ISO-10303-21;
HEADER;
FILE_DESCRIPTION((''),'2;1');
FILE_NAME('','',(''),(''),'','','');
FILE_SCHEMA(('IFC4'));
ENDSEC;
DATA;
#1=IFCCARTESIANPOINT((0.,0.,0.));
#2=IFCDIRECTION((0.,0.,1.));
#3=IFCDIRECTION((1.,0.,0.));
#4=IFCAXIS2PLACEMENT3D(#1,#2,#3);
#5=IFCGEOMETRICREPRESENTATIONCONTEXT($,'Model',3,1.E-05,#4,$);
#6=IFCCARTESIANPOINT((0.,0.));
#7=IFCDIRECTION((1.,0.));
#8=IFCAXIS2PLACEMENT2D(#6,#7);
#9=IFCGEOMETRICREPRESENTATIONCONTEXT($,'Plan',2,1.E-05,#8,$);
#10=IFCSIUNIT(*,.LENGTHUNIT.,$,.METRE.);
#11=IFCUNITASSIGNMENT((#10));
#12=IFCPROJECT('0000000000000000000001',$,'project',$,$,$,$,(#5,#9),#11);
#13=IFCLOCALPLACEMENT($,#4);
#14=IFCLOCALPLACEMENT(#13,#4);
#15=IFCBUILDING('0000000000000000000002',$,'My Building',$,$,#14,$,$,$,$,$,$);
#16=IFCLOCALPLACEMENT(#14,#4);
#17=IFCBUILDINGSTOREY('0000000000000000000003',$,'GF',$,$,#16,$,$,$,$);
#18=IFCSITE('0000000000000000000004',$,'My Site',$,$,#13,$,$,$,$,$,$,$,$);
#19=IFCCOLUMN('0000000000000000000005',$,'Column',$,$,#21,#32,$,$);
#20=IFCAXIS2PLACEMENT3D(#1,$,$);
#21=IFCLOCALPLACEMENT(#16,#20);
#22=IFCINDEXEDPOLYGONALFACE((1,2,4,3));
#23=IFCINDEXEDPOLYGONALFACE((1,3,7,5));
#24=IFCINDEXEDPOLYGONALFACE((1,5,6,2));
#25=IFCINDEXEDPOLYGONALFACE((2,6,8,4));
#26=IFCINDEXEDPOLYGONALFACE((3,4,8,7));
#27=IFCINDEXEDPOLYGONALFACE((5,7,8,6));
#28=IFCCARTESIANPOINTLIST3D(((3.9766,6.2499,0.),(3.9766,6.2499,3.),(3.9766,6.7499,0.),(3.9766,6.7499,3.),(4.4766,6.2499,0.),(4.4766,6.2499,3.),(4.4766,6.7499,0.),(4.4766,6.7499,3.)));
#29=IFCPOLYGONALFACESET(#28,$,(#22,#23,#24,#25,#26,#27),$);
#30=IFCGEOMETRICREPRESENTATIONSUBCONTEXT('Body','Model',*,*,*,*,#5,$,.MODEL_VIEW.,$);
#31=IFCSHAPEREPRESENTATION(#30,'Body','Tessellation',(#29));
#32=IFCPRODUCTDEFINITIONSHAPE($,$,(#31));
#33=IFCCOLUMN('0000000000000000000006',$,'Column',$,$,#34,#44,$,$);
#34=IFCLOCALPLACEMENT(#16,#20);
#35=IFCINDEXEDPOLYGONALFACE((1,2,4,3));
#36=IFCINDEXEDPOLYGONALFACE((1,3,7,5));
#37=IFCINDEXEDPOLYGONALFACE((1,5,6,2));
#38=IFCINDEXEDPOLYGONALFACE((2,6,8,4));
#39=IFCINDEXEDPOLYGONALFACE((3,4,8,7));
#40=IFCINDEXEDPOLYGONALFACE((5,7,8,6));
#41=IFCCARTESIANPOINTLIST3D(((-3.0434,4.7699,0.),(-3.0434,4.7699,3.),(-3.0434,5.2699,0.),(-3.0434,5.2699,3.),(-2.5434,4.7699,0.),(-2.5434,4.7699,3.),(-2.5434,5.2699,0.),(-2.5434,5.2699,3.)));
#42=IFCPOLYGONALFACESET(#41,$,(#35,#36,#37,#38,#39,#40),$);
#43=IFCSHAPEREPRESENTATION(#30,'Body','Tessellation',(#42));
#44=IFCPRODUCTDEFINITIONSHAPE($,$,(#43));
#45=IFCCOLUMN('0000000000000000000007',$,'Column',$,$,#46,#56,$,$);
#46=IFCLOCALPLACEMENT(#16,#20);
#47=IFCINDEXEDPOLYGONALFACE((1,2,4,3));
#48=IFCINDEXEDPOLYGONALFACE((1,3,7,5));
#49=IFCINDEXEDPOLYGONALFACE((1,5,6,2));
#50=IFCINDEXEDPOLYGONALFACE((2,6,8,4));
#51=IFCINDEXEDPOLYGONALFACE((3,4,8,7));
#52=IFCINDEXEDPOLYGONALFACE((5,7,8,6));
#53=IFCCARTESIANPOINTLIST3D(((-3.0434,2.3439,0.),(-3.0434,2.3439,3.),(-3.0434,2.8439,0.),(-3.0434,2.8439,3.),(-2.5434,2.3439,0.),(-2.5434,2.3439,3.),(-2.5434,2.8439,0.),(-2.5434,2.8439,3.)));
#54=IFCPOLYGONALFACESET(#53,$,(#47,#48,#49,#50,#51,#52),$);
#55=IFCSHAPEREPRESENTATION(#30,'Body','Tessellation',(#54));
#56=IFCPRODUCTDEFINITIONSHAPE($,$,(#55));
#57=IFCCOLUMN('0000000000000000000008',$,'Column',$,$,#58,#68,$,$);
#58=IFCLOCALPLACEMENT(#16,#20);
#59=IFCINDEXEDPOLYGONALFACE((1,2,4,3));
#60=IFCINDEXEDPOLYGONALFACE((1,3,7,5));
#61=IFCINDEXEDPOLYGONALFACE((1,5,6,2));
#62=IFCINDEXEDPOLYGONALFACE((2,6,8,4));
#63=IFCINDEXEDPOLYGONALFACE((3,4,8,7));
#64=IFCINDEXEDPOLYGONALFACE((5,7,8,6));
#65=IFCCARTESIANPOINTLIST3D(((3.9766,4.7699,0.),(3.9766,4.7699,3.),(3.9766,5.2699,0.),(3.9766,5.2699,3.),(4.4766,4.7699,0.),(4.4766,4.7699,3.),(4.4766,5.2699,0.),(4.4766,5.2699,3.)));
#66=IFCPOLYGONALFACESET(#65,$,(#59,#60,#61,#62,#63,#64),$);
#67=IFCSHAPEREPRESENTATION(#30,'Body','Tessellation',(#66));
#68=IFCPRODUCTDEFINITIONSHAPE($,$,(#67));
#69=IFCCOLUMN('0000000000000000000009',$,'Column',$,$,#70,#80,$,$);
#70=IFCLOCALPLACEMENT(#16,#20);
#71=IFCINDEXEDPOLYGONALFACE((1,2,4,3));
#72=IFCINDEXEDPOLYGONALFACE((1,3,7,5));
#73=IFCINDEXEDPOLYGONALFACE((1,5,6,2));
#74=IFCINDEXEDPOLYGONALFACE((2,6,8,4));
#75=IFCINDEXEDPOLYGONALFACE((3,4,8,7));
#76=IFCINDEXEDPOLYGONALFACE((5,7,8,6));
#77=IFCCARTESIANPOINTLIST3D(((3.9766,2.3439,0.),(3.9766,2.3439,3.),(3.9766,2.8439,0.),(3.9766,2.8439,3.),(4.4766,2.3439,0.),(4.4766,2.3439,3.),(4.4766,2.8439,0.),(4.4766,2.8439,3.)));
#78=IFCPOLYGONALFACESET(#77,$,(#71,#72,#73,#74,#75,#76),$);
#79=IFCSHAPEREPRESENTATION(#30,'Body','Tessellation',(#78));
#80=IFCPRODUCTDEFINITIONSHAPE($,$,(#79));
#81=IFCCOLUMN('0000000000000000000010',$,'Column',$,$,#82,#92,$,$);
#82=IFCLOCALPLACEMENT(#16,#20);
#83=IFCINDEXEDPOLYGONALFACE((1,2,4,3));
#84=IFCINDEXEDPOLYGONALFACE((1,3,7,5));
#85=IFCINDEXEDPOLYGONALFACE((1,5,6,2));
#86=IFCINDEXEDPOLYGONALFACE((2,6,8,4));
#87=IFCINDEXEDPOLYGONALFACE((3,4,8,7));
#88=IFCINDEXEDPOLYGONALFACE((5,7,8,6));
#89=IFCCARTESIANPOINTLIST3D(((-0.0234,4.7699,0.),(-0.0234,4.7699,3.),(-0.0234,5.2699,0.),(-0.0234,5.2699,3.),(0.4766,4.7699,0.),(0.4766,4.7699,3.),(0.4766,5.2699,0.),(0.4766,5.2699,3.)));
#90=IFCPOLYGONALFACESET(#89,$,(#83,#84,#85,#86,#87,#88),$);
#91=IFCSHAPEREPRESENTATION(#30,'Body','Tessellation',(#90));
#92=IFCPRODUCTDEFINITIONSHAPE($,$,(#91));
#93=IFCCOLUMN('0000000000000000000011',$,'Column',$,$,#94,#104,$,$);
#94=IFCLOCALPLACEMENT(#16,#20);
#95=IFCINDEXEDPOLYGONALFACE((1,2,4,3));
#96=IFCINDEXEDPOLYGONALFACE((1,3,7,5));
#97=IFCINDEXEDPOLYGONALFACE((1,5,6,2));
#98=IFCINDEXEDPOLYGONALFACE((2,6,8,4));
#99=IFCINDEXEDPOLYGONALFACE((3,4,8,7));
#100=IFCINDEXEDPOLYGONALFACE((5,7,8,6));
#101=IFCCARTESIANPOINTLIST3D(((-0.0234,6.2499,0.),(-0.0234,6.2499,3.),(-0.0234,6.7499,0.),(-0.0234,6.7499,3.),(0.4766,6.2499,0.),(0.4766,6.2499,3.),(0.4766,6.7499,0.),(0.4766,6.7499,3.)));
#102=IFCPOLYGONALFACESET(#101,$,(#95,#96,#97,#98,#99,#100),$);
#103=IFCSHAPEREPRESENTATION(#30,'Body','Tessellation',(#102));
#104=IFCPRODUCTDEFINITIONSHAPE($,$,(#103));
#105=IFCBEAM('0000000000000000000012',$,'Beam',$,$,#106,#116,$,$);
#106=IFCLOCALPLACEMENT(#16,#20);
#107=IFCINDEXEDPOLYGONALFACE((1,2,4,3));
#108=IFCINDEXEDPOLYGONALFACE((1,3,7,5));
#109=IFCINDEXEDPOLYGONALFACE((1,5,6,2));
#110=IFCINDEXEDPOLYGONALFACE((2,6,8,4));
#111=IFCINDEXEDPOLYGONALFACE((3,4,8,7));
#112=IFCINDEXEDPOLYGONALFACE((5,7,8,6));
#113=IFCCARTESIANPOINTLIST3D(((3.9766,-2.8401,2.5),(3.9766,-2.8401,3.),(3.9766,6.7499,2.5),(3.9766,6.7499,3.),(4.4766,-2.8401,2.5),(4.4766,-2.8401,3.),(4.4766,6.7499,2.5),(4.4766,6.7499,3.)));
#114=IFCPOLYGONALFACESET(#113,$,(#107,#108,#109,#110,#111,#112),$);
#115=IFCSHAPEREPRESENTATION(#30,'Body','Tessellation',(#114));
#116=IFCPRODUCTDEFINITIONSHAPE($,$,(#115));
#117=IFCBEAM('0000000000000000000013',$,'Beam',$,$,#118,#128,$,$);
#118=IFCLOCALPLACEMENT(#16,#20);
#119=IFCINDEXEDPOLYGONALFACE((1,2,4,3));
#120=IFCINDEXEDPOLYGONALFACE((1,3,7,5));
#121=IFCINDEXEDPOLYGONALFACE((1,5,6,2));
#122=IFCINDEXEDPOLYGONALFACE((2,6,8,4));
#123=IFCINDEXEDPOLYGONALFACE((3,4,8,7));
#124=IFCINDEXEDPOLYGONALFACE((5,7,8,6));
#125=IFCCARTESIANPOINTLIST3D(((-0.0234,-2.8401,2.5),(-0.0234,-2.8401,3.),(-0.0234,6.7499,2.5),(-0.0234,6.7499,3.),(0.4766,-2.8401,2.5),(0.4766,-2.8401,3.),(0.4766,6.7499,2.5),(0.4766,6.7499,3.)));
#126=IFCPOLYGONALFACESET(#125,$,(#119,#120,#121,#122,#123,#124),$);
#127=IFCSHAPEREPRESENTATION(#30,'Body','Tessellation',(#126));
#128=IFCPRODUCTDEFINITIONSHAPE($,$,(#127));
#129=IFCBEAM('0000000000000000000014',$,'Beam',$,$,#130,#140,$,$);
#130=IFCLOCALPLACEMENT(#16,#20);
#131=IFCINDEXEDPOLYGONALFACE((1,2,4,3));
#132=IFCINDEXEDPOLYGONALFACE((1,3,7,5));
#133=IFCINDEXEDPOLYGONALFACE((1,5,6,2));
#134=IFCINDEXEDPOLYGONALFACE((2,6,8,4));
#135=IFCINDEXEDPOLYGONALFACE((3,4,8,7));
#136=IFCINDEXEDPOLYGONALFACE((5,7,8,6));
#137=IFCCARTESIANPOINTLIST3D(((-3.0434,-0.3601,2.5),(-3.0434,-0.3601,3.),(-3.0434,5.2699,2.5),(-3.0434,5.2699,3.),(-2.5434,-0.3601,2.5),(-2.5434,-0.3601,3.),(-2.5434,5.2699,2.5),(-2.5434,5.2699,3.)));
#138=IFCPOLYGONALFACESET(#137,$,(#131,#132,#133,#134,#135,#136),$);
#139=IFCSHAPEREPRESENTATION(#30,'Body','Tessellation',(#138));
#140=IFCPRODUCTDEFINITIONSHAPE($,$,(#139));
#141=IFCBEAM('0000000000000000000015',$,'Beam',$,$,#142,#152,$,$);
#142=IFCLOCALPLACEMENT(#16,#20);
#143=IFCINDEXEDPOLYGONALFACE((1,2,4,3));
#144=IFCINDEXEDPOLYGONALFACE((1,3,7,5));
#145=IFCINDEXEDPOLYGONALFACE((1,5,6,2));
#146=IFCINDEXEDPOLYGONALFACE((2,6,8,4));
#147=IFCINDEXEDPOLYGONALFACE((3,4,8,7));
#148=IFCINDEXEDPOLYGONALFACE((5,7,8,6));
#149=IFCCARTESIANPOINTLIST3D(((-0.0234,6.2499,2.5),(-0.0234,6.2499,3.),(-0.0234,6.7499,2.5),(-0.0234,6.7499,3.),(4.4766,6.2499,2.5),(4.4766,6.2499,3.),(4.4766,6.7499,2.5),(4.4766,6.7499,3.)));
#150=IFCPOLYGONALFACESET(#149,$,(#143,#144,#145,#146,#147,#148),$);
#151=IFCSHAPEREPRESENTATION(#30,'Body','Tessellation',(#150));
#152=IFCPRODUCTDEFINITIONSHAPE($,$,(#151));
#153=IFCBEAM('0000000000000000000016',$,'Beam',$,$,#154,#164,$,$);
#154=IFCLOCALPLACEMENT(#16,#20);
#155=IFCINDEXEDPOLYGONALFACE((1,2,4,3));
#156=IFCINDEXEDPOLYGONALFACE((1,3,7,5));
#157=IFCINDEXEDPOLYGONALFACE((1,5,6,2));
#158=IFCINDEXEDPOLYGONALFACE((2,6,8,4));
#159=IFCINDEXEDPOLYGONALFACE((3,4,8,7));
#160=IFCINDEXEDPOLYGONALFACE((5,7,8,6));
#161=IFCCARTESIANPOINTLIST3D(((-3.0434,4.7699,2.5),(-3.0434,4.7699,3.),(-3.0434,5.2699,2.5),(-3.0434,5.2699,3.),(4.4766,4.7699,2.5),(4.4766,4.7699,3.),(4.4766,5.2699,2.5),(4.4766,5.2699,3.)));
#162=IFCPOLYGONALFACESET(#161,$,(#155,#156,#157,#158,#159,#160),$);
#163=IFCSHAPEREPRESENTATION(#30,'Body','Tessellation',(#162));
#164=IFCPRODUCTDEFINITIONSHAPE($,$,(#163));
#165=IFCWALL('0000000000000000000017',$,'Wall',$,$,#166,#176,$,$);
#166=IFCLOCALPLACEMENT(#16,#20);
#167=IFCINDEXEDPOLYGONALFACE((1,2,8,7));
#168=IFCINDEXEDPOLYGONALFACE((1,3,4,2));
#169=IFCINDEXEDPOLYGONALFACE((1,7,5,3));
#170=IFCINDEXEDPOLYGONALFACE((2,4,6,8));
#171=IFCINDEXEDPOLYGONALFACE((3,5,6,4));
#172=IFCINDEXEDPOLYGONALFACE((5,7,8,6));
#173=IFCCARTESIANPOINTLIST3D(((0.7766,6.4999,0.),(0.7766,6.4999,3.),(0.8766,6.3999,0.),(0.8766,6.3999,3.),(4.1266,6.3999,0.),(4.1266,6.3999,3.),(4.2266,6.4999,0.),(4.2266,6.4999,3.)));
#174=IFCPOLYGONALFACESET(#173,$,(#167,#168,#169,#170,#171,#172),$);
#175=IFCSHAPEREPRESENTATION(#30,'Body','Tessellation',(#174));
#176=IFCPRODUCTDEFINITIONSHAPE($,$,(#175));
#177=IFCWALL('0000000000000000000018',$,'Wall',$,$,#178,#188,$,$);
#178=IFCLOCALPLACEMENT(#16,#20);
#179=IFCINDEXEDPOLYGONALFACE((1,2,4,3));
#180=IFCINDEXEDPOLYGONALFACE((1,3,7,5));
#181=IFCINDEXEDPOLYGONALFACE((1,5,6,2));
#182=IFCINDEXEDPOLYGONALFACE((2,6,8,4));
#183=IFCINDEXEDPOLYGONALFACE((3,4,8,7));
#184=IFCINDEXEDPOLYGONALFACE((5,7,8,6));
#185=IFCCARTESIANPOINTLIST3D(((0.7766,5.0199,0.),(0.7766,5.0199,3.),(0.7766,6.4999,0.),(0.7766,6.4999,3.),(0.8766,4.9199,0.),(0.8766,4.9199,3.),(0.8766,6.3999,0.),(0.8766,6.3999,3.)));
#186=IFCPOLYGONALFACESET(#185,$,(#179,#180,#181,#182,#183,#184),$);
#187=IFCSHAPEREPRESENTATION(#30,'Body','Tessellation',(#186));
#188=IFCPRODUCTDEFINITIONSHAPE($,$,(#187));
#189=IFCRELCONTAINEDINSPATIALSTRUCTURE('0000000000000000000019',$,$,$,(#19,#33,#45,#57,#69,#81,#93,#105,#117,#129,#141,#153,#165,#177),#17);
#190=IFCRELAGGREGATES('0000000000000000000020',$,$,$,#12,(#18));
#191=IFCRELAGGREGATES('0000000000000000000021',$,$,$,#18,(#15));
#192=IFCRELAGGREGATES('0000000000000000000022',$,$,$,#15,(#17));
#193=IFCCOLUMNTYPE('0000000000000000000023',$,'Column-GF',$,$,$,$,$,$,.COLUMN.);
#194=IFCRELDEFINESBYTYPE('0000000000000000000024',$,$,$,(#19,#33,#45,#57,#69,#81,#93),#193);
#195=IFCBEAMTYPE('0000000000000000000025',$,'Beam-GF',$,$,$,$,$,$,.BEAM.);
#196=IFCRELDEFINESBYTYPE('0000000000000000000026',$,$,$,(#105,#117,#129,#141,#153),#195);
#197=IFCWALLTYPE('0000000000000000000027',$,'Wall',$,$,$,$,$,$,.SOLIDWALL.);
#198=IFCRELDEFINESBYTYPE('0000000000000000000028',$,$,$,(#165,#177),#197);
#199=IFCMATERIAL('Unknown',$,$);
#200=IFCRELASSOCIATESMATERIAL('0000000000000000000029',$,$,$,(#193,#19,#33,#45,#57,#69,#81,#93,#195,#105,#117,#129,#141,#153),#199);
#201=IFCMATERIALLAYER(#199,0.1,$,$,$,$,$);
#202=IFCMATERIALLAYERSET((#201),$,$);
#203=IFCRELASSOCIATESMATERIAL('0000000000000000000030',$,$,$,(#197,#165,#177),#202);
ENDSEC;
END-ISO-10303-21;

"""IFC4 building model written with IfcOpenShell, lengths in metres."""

from ifc_helpers import new_model, si_unit, frame, origin_with_axes, origin_2d_with_axis, place, context, subcontext, project, spatial, line, indexed_curve, rectangle, outline, extrude, material, layer, layer_set, layer_usage, material_profile, profile_set, profile_usage, type_object, element, save


model = new_model("IFC4")

# Units and contexts
model_context = context("Model", 3, precision=1e-05, world=origin_with_axes())
plan_context = context("Plan", 2, precision=1e-05, world=origin_2d_with_axis())
body_context_1 = subcontext(model_context, "Body", "Model", "MODEL_VIEW")
ifc_project = project(units=[si_unit("LENGTHUNIT", "METRE")], contexts=[model_context, plan_context])

# Site, building, storey
site_placement = place(None, origin_with_axes())
site = spatial("IfcSite", under=ifc_project, at=site_placement, Name="My Site")
building_placement = place(site_placement, origin_with_axes())
building = spatial("IfcBuilding", under=site, at=building_placement, Name="My Building")
storey_placement = place(building_placement, origin_with_axes())
storey = spatial("IfcBuildingStorey", under=building, at=storey_placement, Name="GF")

# Columns
ifc_material_1 = material(Name="Unknown")
ifc_material_profile_1 = material_profile(ifc_material_1, rectangle(XDim=0.5, YDim=0.5))
ifc_profile_set_1 = profile_set([ifc_material_profile_1])
ifc_profile_usage_1 = profile_usage(ifc_profile_set_1, cardinal=5)
column_type = type_object("IfcColumnType", Name="Column-GF", PredefinedType="COLUMN", material=ifc_profile_set_1)
column_1_placement = place(storey_placement, frame((4.2266, 6.4999, 0.0), z_axis=(0.0, 0.0, 1.0), x_axis=(1.0, 0.0, 0.0)))
element("IfcColumn", 1, at=column_1_placement, inside=storey, type_object=column_type, material=ifc_profile_usage_1, Name="Column", context=body_context_1, shape_type="SweptSolid", body=[
    extrude(rectangle(XDim=0.5, YDim=0.5), origin_with_axes(), (0.0, 0.0, 1.0), 3.0),
])
ifc_profile_usage_2 = profile_usage(ifc_profile_set_1, cardinal=5)
column_2_placement = place(storey_placement, frame((-2.7934, 5.0199, 0.0), z_axis=(0.0, 0.0, 1.0), x_axis=(1.0, 0.0, 0.0)))
element("IfcColumn", 2, at=column_2_placement, inside=storey, type_object=column_type, material=ifc_profile_usage_2, Name="Column", context=body_context_1, shape_type="SweptSolid", body=[
    extrude(rectangle(XDim=0.5, YDim=0.5), origin_with_axes(), (0.0, 0.0, 1.0), 3.0),
])
ifc_profile_usage_3 = profile_usage(ifc_profile_set_1, cardinal=5)
column_3_placement = place(storey_placement, frame((-2.7934, 2.5939, 0.0), z_axis=(0.0, 0.0, 1.0), x_axis=(1.0, 0.0, 0.0)))
element("IfcColumn", 3, at=column_3_placement, inside=storey, type_object=column_type, material=ifc_profile_usage_3, Name="Column", context=body_context_1, shape_type="SweptSolid", body=[
    extrude(rectangle(XDim=0.5, YDim=0.5), origin_with_axes(), (0.0, 0.0, 1.0), 3.0),
])
ifc_profile_usage_4 = profile_usage(ifc_profile_set_1, cardinal=5)
column_4_placement = place(storey_placement, frame((4.2266, 5.0199, 0.0), z_axis=(0.0, 0.0, 1.0), x_axis=(1.0, 0.0, 0.0)))
element("IfcColumn", 4, at=column_4_placement, inside=storey, type_object=column_type, material=ifc_profile_usage_4, Name="Column", context=body_context_1, shape_type="SweptSolid", body=[
    extrude(rectangle(XDim=0.5, YDim=0.5), origin_with_axes(), (0.0, 0.0, 1.0), 3.0),
])
ifc_profile_usage_5 = profile_usage(ifc_profile_set_1, cardinal=5)
column_5_placement = place(storey_placement, frame((4.2266, 2.5939, 0.0), z_axis=(0.0, 0.0, 1.0), x_axis=(1.0, 0.0, 0.0)))
element("IfcColumn", 5, at=column_5_placement, inside=storey, type_object=column_type, material=ifc_profile_usage_5, Name="Column", context=body_context_1, shape_type="SweptSolid", body=[
    extrude(rectangle(XDim=0.5, YDim=0.5), origin_with_axes(), (0.0, 0.0, 1.0), 3.0),
])
ifc_profile_usage_6 = profile_usage(ifc_profile_set_1, cardinal=5)
column_6_placement = place(storey_placement, frame((0.2266, 5.0199, 0.0), z_axis=(0.0, 0.0, 1.0), x_axis=(1.0, 0.0, 0.0)))
element("IfcColumn", 6, at=column_6_placement, inside=storey, type_object=column_type, material=ifc_profile_usage_6, Name="Column", context=body_context_1, shape_type="SweptSolid", body=[
    extrude(rectangle(XDim=0.5, YDim=0.5), origin_with_axes(), (0.0, 0.0, 1.0), 3.0),
])
ifc_profile_usage_7 = profile_usage(ifc_profile_set_1, cardinal=5)
column_7_placement = place(storey_placement, frame((0.2266, 6.4999, 0.0), z_axis=(0.0, 0.0, 1.0), x_axis=(1.0, 0.0, 0.0)))
element("IfcColumn", 7, at=column_7_placement, inside=storey, type_object=column_type, material=ifc_profile_usage_7, Name="Column", context=body_context_1, shape_type="SweptSolid", body=[
    extrude(rectangle(XDim=0.5, YDim=0.5), origin_with_axes(), (0.0, 0.0, 1.0), 3.0),
])

# Beams
ifc_material_profile_2 = material_profile(ifc_material_1, rectangle(XDim=0.5, YDim=0.5))
ifc_profile_set_2 = profile_set([ifc_material_profile_2])
ifc_profile_usage_8 = profile_usage(ifc_profile_set_2, cardinal=7)
beam_type = type_object("IfcBeamType", Name="Beam-GF", PredefinedType="BEAM", material=ifc_profile_set_2)
beam_1_placement = place(storey_placement, frame((4.4766, 6.7499, 3.0), z_axis=(0.0, -1.0, 0.0), x_axis=(1.0, 0.0, 0.0)))
element("IfcBeam", 8, at=beam_1_placement, inside=storey, type_object=beam_type, material=ifc_profile_usage_8, Name="Beam", context=body_context_1, shape_type="SweptSolid", body=[
    extrude(rectangle(XDim=0.5, YDim=0.5), frame((-0.25, -0.25, 0.0), z_axis=(0.0, 0.0, 1.0), x_axis=(1.0, 0.0, 0.0)), (0.0, 0.0, 1.0), 9.59),
])
ifc_profile_usage_9 = profile_usage(ifc_profile_set_2, cardinal=7)
beam_2_placement = place(storey_placement, frame((0.4766, 6.7499, 3.0), z_axis=(0.0, -1.0, 0.0), x_axis=(1.0, 0.0, 0.0)))
element("IfcBeam", 9, at=beam_2_placement, inside=storey, type_object=beam_type, material=ifc_profile_usage_9, Name="Beam", context=body_context_1, shape_type="SweptSolid", body=[
    extrude(rectangle(XDim=0.5, YDim=0.5), frame((-0.25, -0.25, 0.0), z_axis=(0.0, 0.0, 1.0), x_axis=(1.0, 0.0, 0.0)), (0.0, 0.0, 1.0), 9.59),
])
ifc_profile_usage_10 = profile_usage(ifc_profile_set_2, cardinal=7)
beam_3_placement = place(storey_placement, frame((-2.5434, 5.2699, 3.0), z_axis=(0.0, -1.0, 0.0), x_axis=(1.0, 0.0, 0.0)))
element("IfcBeam", 10, at=beam_3_placement, inside=storey, type_object=beam_type, material=ifc_profile_usage_10, Name="Beam", context=body_context_1, shape_type="SweptSolid", body=[
    extrude(rectangle(XDim=0.5, YDim=0.5), frame((-0.25, -0.25, 0.0), z_axis=(0.0, 0.0, 1.0), x_axis=(1.0, 0.0, 0.0)), (0.0, 0.0, 1.0), 5.63),
])
ifc_profile_usage_11 = profile_usage(ifc_profile_set_2, cardinal=7)
beam_4_placement = place(storey_placement, frame((4.4766, 6.2499, 3.0), z_axis=(-1.0, 0.0, 0.0), x_axis=(0.0, -1.0, 0.0)))
element("IfcBeam", 11, at=beam_4_placement, inside=storey, type_object=beam_type, material=ifc_profile_usage_11, Name="Beam", context=body_context_1, shape_type="SweptSolid", body=[
    extrude(rectangle(XDim=0.5, YDim=0.5), frame((-0.25, -0.25, 0.0), z_axis=(0.0, 0.0, 1.0), x_axis=(1.0, 0.0, 0.0)), (0.0, 0.0, 1.0), 4.5),
])
ifc_profile_usage_12 = profile_usage(ifc_profile_set_2, cardinal=7)
beam_5_placement = place(storey_placement, frame((4.4766, 4.7699, 3.0), z_axis=(-1.0, 0.0, 0.0), x_axis=(0.0, -1.0, 0.0)))
element("IfcBeam", 12, at=beam_5_placement, inside=storey, type_object=beam_type, material=ifc_profile_usage_12, Name="Beam", context=body_context_1, shape_type="SweptSolid", body=[
    extrude(rectangle(XDim=0.5, YDim=0.5), frame((-0.25, -0.25, 0.0), z_axis=(0.0, 0.0, 1.0), x_axis=(1.0, 0.0, 0.0)), (0.0, 0.0, 1.0), 7.52),
])

# Walls
ifc_layer_1 = layer(ifc_material_1, 0.1)
ifc_layer_set_1 = layer_set([ifc_layer_1])
ifc_layer_usage_1 = layer_usage(ifc_layer_set_1, "AXIS2", "POSITIVE", 0.0)
wall_type = type_object("IfcWallType", Name="Wall", PredefinedType="SOLIDWALL", material=ifc_layer_set_1)
wall_1_placement = place(storey_placement, frame((4.2266, 6.4999, 0.0), z_axis=(0.0, 0.0, 1.0), x_axis=(-1.0, 0.0, 0.0)))
element("IfcWall", 13, at=wall_1_placement, inside=storey, type_object=wall_type, material=ifc_layer_usage_1, Name="Wall", context=body_context_1, shape_type="SweptSolid", body=[
    extrude(outline(indexed_curve([(0.0, 0.0), (0.1, 0.1), (3.35, 0.1), (3.45, 0.0)], segments=[line(1, 2, 3, 4, 1)])), origin_with_axes(), (0.0, 0.0, 1.0), 3.0),
])
ifc_layer_usage_2 = layer_usage(ifc_layer_set_1, "AXIS2", "POSITIVE", 0.0)
wall_2_placement = place(storey_placement, frame((0.7766, 6.4999, 0.0), z_axis=(0.0, 0.0, 1.0), x_axis=(0.0, -1.0, 0.0)))
element("IfcWall", 14, at=wall_2_placement, inside=storey, type_object=wall_type, material=ifc_layer_usage_2, Name="Wall", context=body_context_1, shape_type="SweptSolid", body=[
    extrude(outline(indexed_curve([(0.0, 0.0), (0.1, 0.1), (1.58, 0.1), (1.48, 0.0)], segments=[line(1, 2, 3, 4, 1)])), origin_with_axes(), (0.0, 0.0, 1.0), 3.0),
])

save(model, "model.ifc")
